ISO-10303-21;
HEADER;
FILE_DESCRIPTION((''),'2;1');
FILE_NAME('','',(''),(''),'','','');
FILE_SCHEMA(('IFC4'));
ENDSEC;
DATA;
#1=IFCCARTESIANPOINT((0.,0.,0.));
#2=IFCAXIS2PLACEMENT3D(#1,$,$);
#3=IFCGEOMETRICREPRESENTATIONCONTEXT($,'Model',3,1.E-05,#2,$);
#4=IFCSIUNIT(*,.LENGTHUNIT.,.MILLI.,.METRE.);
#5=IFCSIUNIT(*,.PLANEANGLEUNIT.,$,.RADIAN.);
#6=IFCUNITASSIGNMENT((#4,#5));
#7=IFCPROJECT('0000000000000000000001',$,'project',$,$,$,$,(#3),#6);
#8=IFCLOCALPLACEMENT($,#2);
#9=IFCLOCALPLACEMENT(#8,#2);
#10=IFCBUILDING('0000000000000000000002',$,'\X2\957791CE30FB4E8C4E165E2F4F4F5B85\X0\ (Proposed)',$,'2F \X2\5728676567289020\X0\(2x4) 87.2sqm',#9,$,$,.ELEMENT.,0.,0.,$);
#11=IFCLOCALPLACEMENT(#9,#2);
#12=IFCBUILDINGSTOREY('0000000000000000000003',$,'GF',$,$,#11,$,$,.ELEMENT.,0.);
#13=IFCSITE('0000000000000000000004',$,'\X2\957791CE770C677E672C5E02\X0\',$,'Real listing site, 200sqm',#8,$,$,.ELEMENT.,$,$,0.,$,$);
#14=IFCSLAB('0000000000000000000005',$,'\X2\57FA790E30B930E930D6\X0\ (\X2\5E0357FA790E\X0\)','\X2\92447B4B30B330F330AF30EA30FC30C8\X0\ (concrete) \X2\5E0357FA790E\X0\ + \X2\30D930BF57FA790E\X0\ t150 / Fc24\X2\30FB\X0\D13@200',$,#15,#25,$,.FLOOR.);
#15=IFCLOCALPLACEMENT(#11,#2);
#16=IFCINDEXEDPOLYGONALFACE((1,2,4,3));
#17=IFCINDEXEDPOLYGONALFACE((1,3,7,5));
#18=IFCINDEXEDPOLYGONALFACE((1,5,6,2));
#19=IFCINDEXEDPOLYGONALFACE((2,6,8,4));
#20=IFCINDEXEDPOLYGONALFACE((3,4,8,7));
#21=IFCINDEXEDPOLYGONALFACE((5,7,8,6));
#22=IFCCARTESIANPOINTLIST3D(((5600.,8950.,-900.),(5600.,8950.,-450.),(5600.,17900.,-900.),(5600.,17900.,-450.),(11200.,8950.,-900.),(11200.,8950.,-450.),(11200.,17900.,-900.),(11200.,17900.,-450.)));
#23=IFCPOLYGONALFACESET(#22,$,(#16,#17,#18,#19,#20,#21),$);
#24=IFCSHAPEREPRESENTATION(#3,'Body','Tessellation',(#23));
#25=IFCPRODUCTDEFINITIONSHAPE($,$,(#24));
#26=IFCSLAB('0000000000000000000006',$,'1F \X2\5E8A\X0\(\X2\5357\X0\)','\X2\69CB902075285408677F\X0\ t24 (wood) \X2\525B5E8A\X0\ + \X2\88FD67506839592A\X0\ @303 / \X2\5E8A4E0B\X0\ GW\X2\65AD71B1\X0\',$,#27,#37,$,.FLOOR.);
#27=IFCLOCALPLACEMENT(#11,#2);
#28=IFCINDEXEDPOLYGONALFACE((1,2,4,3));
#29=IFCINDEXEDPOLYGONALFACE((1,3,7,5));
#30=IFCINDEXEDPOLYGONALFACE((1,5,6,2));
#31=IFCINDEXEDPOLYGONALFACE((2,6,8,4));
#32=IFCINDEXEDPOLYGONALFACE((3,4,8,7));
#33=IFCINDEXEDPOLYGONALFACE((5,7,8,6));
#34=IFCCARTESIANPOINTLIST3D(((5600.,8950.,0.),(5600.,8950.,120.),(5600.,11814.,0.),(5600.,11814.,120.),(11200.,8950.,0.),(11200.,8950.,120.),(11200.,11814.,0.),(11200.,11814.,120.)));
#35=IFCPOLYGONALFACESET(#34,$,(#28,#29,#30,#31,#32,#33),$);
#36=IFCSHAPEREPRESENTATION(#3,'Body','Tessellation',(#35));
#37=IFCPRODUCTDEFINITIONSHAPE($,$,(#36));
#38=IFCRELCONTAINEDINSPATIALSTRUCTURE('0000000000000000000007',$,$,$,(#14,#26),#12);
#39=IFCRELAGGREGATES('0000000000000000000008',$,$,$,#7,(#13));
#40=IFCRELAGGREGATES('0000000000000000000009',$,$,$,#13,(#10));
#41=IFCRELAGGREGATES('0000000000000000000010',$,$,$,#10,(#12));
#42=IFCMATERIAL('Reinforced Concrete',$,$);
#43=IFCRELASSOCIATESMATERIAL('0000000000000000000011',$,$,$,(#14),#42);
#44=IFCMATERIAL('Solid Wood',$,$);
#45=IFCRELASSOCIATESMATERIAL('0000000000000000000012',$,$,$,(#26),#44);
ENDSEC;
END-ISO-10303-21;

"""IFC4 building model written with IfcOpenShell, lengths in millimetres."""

from ifc_helpers import new_model, si_unit, frame, frame_2d, origin, place, context, project, spatial, rectangle, extrude, material, element, save


model = new_model("IFC4")

# Units and contexts
model_context = context("Model", 3, precision=1e-05, world=origin())
ifc_project = project(units=[si_unit("LENGTHUNIT", "METRE", prefix="MILLI"), si_unit("PLANEANGLEUNIT", "RADIAN")], contexts=[model_context])

# Site, building, storey
site_placement = place(None, origin())
site = spatial("IfcSite", under=ifc_project, at=site_placement, Name="長野県松本市", ObjectType="Real listing site, 200sqm", CompositionType="ELEMENT", RefElevation=0.0)
building_placement = place(site_placement, origin())
building = spatial("IfcBuilding", under=site, at=building_placement, Name="長野・二世帯住宅 (Proposed)", ObjectType="2F 在来木造(2x4) 87.2sqm", CompositionType="ELEMENT", ElevationOfRefHeight=0.0, ElevationOfTerrain=0.0)
storey_placement = place(building_placement, origin())
storey = spatial("IfcBuildingStorey", under=building, at=storey_placement, Name="GF", CompositionType="ELEMENT", Elevation=0.0)

# Shared definitions
ifc_material_1 = material(Name="Solid Wood")

# Slabs
ifc_material_2 = material(Name="Reinforced Concrete")
slab_1_placement = place(storey_placement, frame((2800.0, 4475.0, -450.0)))
element("IfcSlab", 1, at=slab_1_placement, inside=storey, material=ifc_material_2, Name="基礎スラブ (布基礎)", Description="鉄筋コンクリート (concrete) 布基礎 + ベタ基礎 t150 / Fc24・D13@200", PredefinedType="FLOOR", context=model_context, shape_type="SweptSolid", body=[
    extrude(rectangle(XDim=5600.0, YDim=8950.0, at=frame_2d((2800.0, 4475.0))), frame((2800.0, 4475.0, -450.0)), (0.0, 0.0, 1.0), 450.0),
])
slab_2_placement = place(storey_placement, frame((2800.0, 4475.0, 0.0)))
element("IfcSlab", 2, at=slab_2_placement, inside=storey, material=ifc_material_1, Name="1F 床(南)", Description="構造用合板 t24 (wood) 剛床 + 製材根太 @303 / 床下 GW断熱", PredefinedType="FLOOR", context=model_context, shape_type="SweptSolid", body=[
    extrude(rectangle(XDim=5600.0, YDim=2864.0, at=frame_2d((2800.0, 1432.0))), frame((2800.0, 4475.0, 0.0)), (0.0, 0.0, 1.0), 120.0),
])

save(model, "model.ifc")
